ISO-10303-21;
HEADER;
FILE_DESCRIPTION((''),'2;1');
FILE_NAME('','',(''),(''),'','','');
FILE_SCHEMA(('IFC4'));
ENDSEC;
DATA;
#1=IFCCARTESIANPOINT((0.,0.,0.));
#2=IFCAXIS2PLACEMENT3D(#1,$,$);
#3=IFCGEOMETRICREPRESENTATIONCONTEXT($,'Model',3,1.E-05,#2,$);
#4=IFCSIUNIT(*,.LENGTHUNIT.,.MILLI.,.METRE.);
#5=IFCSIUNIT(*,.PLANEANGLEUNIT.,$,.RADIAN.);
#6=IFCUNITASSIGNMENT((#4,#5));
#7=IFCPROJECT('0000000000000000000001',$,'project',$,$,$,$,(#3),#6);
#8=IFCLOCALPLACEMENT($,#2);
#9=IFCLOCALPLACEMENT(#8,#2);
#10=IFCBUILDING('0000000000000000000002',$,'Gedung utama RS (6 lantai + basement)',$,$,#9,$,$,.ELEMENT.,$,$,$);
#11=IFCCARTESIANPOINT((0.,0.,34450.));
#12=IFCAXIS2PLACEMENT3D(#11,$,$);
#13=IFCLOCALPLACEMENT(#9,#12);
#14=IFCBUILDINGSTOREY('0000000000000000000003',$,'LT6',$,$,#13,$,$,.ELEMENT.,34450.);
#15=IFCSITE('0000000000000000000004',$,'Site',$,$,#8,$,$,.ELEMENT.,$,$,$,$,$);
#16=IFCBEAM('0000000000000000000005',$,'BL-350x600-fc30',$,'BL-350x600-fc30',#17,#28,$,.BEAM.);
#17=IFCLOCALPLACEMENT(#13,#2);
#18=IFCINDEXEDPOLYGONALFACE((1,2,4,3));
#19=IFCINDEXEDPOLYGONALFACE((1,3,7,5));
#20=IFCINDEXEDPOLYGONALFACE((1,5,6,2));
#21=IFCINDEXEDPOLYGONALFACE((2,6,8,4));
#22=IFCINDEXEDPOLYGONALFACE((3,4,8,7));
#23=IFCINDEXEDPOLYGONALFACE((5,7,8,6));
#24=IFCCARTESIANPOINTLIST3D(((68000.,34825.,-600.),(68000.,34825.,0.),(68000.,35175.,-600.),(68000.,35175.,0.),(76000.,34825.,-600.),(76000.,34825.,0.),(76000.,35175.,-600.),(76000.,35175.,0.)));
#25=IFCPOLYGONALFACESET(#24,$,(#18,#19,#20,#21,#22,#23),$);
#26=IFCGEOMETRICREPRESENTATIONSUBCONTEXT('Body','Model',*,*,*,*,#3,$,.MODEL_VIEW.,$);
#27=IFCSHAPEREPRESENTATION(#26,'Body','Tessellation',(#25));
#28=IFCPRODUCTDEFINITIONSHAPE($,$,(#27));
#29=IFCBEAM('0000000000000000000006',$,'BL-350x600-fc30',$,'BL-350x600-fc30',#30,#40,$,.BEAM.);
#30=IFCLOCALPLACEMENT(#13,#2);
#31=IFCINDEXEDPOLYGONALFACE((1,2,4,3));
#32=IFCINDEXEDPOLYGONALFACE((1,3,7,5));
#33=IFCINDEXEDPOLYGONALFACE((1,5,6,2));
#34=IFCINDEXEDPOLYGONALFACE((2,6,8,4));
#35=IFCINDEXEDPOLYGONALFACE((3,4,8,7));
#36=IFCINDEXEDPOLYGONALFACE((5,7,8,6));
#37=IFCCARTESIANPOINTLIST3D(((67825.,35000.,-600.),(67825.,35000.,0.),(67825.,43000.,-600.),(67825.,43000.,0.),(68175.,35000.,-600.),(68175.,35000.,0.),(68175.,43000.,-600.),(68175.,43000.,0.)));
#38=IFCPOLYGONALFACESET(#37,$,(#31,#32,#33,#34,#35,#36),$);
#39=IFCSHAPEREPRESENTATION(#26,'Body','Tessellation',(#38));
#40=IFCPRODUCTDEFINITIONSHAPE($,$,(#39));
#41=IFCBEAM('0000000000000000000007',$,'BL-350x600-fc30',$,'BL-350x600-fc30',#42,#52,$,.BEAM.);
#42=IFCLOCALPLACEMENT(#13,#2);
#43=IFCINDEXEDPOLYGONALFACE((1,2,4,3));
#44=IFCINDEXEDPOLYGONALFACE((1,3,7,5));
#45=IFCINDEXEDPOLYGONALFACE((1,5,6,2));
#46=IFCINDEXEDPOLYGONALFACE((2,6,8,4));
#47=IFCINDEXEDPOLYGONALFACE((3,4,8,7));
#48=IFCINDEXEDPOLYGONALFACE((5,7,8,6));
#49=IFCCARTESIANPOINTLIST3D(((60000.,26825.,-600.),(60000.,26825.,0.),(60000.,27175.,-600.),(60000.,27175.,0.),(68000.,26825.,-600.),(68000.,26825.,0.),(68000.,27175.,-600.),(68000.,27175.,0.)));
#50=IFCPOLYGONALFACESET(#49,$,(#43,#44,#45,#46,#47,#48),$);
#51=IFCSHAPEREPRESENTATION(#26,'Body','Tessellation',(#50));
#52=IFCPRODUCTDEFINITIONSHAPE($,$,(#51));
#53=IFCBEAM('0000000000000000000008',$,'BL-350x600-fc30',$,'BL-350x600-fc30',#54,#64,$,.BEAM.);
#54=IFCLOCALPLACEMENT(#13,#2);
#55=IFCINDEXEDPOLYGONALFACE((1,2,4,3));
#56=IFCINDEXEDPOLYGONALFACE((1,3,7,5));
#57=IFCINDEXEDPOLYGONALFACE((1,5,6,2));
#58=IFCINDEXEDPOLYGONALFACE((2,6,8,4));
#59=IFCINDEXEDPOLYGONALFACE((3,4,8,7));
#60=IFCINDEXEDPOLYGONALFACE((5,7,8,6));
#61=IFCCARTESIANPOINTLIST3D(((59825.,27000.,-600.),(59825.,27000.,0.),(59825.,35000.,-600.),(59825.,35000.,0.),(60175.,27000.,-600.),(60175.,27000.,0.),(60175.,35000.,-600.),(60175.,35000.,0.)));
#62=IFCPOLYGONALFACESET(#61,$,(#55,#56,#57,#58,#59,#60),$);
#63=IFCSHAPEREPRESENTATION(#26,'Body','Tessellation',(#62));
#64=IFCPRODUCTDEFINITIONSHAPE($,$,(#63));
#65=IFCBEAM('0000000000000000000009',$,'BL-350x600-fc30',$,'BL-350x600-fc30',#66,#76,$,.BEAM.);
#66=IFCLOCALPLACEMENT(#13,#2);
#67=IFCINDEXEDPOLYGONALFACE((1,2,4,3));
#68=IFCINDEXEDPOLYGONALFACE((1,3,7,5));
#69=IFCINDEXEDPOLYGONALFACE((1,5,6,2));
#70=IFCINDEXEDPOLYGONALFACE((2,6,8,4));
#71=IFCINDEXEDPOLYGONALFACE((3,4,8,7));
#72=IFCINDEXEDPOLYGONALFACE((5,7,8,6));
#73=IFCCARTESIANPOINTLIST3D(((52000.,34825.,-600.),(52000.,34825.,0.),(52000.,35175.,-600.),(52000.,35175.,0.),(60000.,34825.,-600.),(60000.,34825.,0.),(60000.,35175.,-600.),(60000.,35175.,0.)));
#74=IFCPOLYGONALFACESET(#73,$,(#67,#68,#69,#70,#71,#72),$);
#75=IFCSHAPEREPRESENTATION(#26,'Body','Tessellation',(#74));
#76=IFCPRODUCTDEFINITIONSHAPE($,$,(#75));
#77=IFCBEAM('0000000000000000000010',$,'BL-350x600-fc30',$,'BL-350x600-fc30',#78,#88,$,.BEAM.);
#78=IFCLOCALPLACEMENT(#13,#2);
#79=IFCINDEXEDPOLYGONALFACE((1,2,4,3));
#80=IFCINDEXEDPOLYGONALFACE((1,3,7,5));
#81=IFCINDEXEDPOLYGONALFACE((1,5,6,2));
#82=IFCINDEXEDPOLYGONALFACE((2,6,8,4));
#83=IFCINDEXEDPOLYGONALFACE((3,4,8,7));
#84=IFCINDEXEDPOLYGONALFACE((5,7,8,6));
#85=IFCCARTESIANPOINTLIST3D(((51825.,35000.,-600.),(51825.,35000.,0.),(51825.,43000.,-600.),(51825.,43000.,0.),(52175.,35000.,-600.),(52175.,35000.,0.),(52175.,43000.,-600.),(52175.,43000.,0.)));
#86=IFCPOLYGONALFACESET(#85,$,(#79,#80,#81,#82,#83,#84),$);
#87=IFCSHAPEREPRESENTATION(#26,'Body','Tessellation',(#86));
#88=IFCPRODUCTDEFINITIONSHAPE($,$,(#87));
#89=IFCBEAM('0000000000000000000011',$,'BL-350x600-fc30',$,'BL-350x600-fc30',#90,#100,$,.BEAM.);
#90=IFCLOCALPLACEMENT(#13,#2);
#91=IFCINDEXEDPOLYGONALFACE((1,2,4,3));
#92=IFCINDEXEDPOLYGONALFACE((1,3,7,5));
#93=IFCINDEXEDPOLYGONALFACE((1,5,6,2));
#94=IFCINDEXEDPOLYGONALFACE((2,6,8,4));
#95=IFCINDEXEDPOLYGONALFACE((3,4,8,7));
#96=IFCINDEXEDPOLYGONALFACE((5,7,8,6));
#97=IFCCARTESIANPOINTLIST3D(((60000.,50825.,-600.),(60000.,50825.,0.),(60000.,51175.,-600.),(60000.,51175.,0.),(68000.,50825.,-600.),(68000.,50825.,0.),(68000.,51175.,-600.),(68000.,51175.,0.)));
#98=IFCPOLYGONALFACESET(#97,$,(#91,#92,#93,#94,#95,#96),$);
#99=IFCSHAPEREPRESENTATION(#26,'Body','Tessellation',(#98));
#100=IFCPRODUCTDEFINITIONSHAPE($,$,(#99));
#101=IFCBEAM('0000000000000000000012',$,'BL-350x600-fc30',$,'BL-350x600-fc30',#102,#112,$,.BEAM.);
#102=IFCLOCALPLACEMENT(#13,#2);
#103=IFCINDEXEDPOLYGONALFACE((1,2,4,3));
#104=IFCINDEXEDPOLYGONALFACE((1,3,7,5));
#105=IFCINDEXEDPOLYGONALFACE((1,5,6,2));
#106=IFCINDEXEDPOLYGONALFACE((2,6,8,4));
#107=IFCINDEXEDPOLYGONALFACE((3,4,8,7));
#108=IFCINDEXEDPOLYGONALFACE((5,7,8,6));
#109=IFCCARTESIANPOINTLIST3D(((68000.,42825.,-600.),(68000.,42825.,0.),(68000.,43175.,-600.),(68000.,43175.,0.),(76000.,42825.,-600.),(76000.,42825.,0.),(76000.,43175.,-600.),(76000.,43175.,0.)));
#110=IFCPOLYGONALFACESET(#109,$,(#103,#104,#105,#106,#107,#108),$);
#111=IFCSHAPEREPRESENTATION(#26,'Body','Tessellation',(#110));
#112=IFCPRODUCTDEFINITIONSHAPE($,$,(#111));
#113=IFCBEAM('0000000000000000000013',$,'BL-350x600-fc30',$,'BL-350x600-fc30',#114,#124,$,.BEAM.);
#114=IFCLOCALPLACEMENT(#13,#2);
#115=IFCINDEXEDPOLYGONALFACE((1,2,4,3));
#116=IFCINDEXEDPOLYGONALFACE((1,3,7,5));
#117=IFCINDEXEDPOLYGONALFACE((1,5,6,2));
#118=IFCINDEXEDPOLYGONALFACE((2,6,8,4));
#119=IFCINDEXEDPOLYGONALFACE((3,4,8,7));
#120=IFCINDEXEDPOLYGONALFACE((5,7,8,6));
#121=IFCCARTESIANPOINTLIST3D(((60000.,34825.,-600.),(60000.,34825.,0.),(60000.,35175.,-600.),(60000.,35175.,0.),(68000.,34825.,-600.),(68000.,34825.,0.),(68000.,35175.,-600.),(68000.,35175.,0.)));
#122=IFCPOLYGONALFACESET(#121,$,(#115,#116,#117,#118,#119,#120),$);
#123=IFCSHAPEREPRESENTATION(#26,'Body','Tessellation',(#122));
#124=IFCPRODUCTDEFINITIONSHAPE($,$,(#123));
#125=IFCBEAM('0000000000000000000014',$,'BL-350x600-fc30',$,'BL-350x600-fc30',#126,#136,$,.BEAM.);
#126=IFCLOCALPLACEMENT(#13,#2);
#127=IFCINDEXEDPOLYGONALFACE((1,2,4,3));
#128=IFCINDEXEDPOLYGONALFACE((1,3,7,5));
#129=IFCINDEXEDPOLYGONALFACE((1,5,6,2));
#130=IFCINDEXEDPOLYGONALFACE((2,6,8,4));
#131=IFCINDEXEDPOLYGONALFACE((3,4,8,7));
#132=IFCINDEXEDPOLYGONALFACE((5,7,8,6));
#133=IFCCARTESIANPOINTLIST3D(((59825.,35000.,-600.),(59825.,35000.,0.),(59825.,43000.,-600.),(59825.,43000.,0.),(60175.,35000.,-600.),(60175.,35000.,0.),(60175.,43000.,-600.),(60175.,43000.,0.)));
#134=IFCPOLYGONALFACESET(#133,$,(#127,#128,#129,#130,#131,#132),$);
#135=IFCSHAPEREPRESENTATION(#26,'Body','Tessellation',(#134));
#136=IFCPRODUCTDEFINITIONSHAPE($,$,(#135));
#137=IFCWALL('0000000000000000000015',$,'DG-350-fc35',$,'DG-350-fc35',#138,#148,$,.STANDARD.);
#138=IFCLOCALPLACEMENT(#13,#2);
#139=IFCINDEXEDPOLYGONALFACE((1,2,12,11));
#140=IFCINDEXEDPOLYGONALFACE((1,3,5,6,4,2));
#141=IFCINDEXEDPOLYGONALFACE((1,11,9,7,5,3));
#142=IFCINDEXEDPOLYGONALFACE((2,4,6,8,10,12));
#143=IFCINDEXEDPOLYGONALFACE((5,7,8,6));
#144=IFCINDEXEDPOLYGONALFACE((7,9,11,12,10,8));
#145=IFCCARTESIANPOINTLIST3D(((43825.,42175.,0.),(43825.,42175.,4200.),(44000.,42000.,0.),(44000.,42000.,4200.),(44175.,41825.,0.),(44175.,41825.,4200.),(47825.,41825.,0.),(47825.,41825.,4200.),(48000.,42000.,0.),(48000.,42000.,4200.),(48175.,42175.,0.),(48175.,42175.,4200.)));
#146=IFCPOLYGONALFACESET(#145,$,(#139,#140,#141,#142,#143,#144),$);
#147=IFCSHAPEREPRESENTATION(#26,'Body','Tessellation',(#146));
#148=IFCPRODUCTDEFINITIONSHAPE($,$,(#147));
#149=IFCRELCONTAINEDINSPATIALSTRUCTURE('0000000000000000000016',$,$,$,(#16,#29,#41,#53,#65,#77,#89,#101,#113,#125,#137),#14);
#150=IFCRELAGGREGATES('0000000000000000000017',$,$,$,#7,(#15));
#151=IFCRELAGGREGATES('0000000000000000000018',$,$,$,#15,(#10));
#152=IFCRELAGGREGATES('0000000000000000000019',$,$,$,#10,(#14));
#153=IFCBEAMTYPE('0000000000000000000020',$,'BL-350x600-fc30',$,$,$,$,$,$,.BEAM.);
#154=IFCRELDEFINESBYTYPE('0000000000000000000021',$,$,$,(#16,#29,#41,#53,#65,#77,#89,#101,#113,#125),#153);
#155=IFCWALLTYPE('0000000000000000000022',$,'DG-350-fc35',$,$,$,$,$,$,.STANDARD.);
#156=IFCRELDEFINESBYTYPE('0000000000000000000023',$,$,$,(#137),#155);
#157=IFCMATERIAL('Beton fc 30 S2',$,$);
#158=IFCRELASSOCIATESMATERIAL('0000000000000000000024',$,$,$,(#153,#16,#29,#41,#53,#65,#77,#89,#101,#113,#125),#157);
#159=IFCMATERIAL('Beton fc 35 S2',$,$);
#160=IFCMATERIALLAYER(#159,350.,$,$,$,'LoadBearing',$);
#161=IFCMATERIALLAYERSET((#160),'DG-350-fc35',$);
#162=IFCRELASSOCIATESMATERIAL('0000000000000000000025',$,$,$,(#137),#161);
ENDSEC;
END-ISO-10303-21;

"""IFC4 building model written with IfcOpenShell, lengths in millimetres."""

from ifc_helpers import new_model, si_unit, frame, origin, origin_2d, place, context, subcontext, project, spatial, polyline, rectangle, outline, extrude, material, layer, layer_set, layer_usage, material_profile, profile_set, profile_usage, type_object, element, save


model = new_model("IFC4")

# Units and contexts
model_context = context("Model", 3, precision=1e-05, world=origin())
body_context = subcontext(model_context, "Body", "Model", "MODEL_VIEW")
ifc_project = project(units=[si_unit("LENGTHUNIT", "METRE", prefix="MILLI"), si_unit("PLANEANGLEUNIT", "RADIAN")], contexts=[model_context])

# Site, building, storey
site_placement = place(None, origin())
site = spatial("IfcSite", under=ifc_project, at=site_placement, Name="Site", CompositionType="ELEMENT")
building_placement = place(site_placement, origin())
building = spatial("IfcBuilding", under=site, at=building_placement, Name="Gedung utama RS (6 lantai + basement)", CompositionType="ELEMENT")
storey_placement = place(building_placement, frame((0.0, 0.0, 34450.0)))
storey = spatial("IfcBuildingStorey", under=building, at=storey_placement, Name="LT6", CompositionType="ELEMENT", Elevation=34450.0)

# Beams
ifc_material_1 = material(Name="Beton fc 30 S2")
ifc_material_profile_1 = material_profile(ifc_material_1, rectangle(XDim=350.0, YDim=600.0, at=origin_2d()), Name="BL-350x600-fc30")
ifc_profile_set_1 = profile_set([ifc_material_profile_1], Name="BL-350x600-fc30")
ifc_profile_usage_1 = profile_usage(ifc_profile_set_1, cardinal=8)
beam_type = type_object("IfcBeamType", Name="BL-350x600-fc30", PredefinedType="BEAM", material=ifc_profile_set_1)
for number, where, name in (
    (1, (68000.0, 35000.0, -300.0), "BL-350x600-fc30"),
):
    element("IfcBeam", number, at=place(storey_placement, frame(where)), inside=storey, type_object=beam_type, material=ifc_profile_usage_1, Name=name, ObjectType="BL-350x600-fc30", PredefinedType="BEAM", context=body_context, shape_type="SweptSolid", body=[
        extrude(rectangle(XDim=350.0, YDim=600.0, at=origin_2d()), frame((0.0, 0.0, 0.0), z_axis=(1.0, 0.0, 0.0), x_axis=(0.0, 1.0, 0.0)), (0.0, 0.0, 1.0), 8000.0),
    ])
beam_1_placement = place(storey_placement, frame((68000.0, 35000.0, -300.0)))
element("IfcBeam", 2, at=beam_1_placement, inside=storey, type_object=beam_type, material=ifc_profile_usage_1, Name="BL-350x600-fc30", ObjectType="BL-350x600-fc30", PredefinedType="BEAM", context=body_context, shape_type="SweptSolid", body=[
    extrude(rectangle(XDim=350.0, YDim=600.0, at=origin_2d()), frame((0.0, 0.0, 0.0), z_axis=(0.0, 1.0, 0.0), x_axis=(-1.0, 0.0, 0.0)), (0.0, 0.0, 1.0), 8000.0),
])
beam_2_placement = place(storey_placement, frame((60000.0, 27000.0, -300.0)))
element("IfcBeam", 3, at=beam_2_placement, inside=storey, type_object=beam_type, material=ifc_profile_usage_1, Name="BL-350x600-fc30", ObjectType="BL-350x600-fc30", PredefinedType="BEAM", context=body_context, shape_type="SweptSolid", body=[
    extrude(rectangle(XDim=350.0, YDim=600.0, at=origin_2d()), frame((0.0, 0.0, 0.0), z_axis=(1.0, 0.0, 0.0), x_axis=(0.0, 1.0, 0.0)), (0.0, 0.0, 1.0), 8000.0),
])
beam_3_placement = place(storey_placement, frame((60000.0, 27000.0, -300.0)))
element("IfcBeam", 4, at=beam_3_placement, inside=storey, type_object=beam_type, material=ifc_profile_usage_1, Name="BL-350x600-fc30", ObjectType="BL-350x600-fc30", PredefinedType="BEAM", context=body_context, shape_type="SweptSolid", body=[
    extrude(rectangle(XDim=350.0, YDim=600.0, at=origin_2d()), frame((0.0, 0.0, 0.0), z_axis=(0.0, 1.0, 0.0), x_axis=(-1.0, 0.0, 0.0)), (0.0, 0.0, 1.0), 8000.0),
])
beam_4_placement = place(storey_placement, frame((52000.0, 35000.0, -300.0)))
element("IfcBeam", 5, at=beam_4_placement, inside=storey, type_object=beam_type, material=ifc_profile_usage_1, Name="BL-350x600-fc30", ObjectType="BL-350x600-fc30", PredefinedType="BEAM", context=body_context, shape_type="SweptSolid", body=[
    extrude(rectangle(XDim=350.0, YDim=600.0, at=origin_2d()), frame((0.0, 0.0, 0.0), z_axis=(1.0, 0.0, 0.0), x_axis=(0.0, 1.0, 0.0)), (0.0, 0.0, 1.0), 8000.0),
])
beam_5_placement = place(storey_placement, frame((52000.0, 35000.0, -300.0)))
element("IfcBeam", 6, at=beam_5_placement, inside=storey, type_object=beam_type, material=ifc_profile_usage_1, Name="BL-350x600-fc30", ObjectType="BL-350x600-fc30", PredefinedType="BEAM", context=body_context, shape_type="SweptSolid", body=[
    extrude(rectangle(XDim=350.0, YDim=600.0, at=origin_2d()), frame((0.0, 0.0, 0.0), z_axis=(0.0, 1.0, 0.0), x_axis=(-1.0, 0.0, 0.0)), (0.0, 0.0, 1.0), 8000.0),
])
for number, where, name in (
    (7, (60000.0, 51000.0, -300.0), "BL-350x600-fc30"),
    (8, (68000.0, 43000.0, -300.0), "BL-350x600-fc30"),
    (9, (60000.0, 35000.0, -300.0), "BL-350x600-fc30"),
):
    element("IfcBeam", number, at=place(storey_placement, frame(where)), inside=storey, type_object=beam_type, material=ifc_profile_usage_1, Name=name, ObjectType="BL-350x600-fc30", PredefinedType="BEAM", context=body_context, shape_type="SweptSolid", body=[
        extrude(rectangle(XDim=350.0, YDim=600.0, at=origin_2d()), frame((0.0, 0.0, 0.0), z_axis=(1.0, 0.0, 0.0), x_axis=(0.0, 1.0, 0.0)), (0.0, 0.0, 1.0), 8000.0),
    ])
beam_6_placement = place(storey_placement, frame((60000.0, 35000.0, -300.0)))
element("IfcBeam", 10, at=beam_6_placement, inside=storey, type_object=beam_type, material=ifc_profile_usage_1, Name="BL-350x600-fc30", ObjectType="BL-350x600-fc30", PredefinedType="BEAM", context=body_context, shape_type="SweptSolid", body=[
    extrude(rectangle(XDim=350.0, YDim=600.0, at=origin_2d()), frame((0.0, 0.0, 0.0), z_axis=(0.0, 1.0, 0.0), x_axis=(-1.0, 0.0, 0.0)), (0.0, 0.0, 1.0), 8000.0),
])

# Wall
ifc_material_2 = material(Name="Beton fc 35 S2")
ifc_layer = layer(ifc_material_2, 350.0, Category="LoadBearing")
ifc_layer_set = layer_set([ifc_layer], Name="DG-350-fc35")
ifc_layer_usage = layer_usage(ifc_layer_set, "AXIS2", "NEGATIVE", 175.0)
wall_type = type_object("IfcWallType", Name="DG-350-fc35", PredefinedType="STANDARD")
wall_1_placement = place(storey_placement, frame((48000.0, 42000.0, 0.0), z_axis=(0.0, 0.0, 1.0), x_axis=(-1.0, 0.0, 0.0)))
element("IfcWall", 11, at=wall_1_placement, inside=storey, type_object=wall_type, material=ifc_layer_usage, Name="DG-350-fc35", ObjectType="DG-350-fc35", PredefinedType="STANDARD", context=body_context, shape_type="SweptSolid", body=[
    extrude(outline(polyline([(-175.0, -175.0), (0.0, 0.0), (175.0, 175.0), (3825.0, 175.0), (4000.0, 0.0), (4175.0, -175.0), (-175.0, -175.0)])), origin(), (0.0, 0.0, 1.0), 4200.0),
])

save(model, "model.ifc")
